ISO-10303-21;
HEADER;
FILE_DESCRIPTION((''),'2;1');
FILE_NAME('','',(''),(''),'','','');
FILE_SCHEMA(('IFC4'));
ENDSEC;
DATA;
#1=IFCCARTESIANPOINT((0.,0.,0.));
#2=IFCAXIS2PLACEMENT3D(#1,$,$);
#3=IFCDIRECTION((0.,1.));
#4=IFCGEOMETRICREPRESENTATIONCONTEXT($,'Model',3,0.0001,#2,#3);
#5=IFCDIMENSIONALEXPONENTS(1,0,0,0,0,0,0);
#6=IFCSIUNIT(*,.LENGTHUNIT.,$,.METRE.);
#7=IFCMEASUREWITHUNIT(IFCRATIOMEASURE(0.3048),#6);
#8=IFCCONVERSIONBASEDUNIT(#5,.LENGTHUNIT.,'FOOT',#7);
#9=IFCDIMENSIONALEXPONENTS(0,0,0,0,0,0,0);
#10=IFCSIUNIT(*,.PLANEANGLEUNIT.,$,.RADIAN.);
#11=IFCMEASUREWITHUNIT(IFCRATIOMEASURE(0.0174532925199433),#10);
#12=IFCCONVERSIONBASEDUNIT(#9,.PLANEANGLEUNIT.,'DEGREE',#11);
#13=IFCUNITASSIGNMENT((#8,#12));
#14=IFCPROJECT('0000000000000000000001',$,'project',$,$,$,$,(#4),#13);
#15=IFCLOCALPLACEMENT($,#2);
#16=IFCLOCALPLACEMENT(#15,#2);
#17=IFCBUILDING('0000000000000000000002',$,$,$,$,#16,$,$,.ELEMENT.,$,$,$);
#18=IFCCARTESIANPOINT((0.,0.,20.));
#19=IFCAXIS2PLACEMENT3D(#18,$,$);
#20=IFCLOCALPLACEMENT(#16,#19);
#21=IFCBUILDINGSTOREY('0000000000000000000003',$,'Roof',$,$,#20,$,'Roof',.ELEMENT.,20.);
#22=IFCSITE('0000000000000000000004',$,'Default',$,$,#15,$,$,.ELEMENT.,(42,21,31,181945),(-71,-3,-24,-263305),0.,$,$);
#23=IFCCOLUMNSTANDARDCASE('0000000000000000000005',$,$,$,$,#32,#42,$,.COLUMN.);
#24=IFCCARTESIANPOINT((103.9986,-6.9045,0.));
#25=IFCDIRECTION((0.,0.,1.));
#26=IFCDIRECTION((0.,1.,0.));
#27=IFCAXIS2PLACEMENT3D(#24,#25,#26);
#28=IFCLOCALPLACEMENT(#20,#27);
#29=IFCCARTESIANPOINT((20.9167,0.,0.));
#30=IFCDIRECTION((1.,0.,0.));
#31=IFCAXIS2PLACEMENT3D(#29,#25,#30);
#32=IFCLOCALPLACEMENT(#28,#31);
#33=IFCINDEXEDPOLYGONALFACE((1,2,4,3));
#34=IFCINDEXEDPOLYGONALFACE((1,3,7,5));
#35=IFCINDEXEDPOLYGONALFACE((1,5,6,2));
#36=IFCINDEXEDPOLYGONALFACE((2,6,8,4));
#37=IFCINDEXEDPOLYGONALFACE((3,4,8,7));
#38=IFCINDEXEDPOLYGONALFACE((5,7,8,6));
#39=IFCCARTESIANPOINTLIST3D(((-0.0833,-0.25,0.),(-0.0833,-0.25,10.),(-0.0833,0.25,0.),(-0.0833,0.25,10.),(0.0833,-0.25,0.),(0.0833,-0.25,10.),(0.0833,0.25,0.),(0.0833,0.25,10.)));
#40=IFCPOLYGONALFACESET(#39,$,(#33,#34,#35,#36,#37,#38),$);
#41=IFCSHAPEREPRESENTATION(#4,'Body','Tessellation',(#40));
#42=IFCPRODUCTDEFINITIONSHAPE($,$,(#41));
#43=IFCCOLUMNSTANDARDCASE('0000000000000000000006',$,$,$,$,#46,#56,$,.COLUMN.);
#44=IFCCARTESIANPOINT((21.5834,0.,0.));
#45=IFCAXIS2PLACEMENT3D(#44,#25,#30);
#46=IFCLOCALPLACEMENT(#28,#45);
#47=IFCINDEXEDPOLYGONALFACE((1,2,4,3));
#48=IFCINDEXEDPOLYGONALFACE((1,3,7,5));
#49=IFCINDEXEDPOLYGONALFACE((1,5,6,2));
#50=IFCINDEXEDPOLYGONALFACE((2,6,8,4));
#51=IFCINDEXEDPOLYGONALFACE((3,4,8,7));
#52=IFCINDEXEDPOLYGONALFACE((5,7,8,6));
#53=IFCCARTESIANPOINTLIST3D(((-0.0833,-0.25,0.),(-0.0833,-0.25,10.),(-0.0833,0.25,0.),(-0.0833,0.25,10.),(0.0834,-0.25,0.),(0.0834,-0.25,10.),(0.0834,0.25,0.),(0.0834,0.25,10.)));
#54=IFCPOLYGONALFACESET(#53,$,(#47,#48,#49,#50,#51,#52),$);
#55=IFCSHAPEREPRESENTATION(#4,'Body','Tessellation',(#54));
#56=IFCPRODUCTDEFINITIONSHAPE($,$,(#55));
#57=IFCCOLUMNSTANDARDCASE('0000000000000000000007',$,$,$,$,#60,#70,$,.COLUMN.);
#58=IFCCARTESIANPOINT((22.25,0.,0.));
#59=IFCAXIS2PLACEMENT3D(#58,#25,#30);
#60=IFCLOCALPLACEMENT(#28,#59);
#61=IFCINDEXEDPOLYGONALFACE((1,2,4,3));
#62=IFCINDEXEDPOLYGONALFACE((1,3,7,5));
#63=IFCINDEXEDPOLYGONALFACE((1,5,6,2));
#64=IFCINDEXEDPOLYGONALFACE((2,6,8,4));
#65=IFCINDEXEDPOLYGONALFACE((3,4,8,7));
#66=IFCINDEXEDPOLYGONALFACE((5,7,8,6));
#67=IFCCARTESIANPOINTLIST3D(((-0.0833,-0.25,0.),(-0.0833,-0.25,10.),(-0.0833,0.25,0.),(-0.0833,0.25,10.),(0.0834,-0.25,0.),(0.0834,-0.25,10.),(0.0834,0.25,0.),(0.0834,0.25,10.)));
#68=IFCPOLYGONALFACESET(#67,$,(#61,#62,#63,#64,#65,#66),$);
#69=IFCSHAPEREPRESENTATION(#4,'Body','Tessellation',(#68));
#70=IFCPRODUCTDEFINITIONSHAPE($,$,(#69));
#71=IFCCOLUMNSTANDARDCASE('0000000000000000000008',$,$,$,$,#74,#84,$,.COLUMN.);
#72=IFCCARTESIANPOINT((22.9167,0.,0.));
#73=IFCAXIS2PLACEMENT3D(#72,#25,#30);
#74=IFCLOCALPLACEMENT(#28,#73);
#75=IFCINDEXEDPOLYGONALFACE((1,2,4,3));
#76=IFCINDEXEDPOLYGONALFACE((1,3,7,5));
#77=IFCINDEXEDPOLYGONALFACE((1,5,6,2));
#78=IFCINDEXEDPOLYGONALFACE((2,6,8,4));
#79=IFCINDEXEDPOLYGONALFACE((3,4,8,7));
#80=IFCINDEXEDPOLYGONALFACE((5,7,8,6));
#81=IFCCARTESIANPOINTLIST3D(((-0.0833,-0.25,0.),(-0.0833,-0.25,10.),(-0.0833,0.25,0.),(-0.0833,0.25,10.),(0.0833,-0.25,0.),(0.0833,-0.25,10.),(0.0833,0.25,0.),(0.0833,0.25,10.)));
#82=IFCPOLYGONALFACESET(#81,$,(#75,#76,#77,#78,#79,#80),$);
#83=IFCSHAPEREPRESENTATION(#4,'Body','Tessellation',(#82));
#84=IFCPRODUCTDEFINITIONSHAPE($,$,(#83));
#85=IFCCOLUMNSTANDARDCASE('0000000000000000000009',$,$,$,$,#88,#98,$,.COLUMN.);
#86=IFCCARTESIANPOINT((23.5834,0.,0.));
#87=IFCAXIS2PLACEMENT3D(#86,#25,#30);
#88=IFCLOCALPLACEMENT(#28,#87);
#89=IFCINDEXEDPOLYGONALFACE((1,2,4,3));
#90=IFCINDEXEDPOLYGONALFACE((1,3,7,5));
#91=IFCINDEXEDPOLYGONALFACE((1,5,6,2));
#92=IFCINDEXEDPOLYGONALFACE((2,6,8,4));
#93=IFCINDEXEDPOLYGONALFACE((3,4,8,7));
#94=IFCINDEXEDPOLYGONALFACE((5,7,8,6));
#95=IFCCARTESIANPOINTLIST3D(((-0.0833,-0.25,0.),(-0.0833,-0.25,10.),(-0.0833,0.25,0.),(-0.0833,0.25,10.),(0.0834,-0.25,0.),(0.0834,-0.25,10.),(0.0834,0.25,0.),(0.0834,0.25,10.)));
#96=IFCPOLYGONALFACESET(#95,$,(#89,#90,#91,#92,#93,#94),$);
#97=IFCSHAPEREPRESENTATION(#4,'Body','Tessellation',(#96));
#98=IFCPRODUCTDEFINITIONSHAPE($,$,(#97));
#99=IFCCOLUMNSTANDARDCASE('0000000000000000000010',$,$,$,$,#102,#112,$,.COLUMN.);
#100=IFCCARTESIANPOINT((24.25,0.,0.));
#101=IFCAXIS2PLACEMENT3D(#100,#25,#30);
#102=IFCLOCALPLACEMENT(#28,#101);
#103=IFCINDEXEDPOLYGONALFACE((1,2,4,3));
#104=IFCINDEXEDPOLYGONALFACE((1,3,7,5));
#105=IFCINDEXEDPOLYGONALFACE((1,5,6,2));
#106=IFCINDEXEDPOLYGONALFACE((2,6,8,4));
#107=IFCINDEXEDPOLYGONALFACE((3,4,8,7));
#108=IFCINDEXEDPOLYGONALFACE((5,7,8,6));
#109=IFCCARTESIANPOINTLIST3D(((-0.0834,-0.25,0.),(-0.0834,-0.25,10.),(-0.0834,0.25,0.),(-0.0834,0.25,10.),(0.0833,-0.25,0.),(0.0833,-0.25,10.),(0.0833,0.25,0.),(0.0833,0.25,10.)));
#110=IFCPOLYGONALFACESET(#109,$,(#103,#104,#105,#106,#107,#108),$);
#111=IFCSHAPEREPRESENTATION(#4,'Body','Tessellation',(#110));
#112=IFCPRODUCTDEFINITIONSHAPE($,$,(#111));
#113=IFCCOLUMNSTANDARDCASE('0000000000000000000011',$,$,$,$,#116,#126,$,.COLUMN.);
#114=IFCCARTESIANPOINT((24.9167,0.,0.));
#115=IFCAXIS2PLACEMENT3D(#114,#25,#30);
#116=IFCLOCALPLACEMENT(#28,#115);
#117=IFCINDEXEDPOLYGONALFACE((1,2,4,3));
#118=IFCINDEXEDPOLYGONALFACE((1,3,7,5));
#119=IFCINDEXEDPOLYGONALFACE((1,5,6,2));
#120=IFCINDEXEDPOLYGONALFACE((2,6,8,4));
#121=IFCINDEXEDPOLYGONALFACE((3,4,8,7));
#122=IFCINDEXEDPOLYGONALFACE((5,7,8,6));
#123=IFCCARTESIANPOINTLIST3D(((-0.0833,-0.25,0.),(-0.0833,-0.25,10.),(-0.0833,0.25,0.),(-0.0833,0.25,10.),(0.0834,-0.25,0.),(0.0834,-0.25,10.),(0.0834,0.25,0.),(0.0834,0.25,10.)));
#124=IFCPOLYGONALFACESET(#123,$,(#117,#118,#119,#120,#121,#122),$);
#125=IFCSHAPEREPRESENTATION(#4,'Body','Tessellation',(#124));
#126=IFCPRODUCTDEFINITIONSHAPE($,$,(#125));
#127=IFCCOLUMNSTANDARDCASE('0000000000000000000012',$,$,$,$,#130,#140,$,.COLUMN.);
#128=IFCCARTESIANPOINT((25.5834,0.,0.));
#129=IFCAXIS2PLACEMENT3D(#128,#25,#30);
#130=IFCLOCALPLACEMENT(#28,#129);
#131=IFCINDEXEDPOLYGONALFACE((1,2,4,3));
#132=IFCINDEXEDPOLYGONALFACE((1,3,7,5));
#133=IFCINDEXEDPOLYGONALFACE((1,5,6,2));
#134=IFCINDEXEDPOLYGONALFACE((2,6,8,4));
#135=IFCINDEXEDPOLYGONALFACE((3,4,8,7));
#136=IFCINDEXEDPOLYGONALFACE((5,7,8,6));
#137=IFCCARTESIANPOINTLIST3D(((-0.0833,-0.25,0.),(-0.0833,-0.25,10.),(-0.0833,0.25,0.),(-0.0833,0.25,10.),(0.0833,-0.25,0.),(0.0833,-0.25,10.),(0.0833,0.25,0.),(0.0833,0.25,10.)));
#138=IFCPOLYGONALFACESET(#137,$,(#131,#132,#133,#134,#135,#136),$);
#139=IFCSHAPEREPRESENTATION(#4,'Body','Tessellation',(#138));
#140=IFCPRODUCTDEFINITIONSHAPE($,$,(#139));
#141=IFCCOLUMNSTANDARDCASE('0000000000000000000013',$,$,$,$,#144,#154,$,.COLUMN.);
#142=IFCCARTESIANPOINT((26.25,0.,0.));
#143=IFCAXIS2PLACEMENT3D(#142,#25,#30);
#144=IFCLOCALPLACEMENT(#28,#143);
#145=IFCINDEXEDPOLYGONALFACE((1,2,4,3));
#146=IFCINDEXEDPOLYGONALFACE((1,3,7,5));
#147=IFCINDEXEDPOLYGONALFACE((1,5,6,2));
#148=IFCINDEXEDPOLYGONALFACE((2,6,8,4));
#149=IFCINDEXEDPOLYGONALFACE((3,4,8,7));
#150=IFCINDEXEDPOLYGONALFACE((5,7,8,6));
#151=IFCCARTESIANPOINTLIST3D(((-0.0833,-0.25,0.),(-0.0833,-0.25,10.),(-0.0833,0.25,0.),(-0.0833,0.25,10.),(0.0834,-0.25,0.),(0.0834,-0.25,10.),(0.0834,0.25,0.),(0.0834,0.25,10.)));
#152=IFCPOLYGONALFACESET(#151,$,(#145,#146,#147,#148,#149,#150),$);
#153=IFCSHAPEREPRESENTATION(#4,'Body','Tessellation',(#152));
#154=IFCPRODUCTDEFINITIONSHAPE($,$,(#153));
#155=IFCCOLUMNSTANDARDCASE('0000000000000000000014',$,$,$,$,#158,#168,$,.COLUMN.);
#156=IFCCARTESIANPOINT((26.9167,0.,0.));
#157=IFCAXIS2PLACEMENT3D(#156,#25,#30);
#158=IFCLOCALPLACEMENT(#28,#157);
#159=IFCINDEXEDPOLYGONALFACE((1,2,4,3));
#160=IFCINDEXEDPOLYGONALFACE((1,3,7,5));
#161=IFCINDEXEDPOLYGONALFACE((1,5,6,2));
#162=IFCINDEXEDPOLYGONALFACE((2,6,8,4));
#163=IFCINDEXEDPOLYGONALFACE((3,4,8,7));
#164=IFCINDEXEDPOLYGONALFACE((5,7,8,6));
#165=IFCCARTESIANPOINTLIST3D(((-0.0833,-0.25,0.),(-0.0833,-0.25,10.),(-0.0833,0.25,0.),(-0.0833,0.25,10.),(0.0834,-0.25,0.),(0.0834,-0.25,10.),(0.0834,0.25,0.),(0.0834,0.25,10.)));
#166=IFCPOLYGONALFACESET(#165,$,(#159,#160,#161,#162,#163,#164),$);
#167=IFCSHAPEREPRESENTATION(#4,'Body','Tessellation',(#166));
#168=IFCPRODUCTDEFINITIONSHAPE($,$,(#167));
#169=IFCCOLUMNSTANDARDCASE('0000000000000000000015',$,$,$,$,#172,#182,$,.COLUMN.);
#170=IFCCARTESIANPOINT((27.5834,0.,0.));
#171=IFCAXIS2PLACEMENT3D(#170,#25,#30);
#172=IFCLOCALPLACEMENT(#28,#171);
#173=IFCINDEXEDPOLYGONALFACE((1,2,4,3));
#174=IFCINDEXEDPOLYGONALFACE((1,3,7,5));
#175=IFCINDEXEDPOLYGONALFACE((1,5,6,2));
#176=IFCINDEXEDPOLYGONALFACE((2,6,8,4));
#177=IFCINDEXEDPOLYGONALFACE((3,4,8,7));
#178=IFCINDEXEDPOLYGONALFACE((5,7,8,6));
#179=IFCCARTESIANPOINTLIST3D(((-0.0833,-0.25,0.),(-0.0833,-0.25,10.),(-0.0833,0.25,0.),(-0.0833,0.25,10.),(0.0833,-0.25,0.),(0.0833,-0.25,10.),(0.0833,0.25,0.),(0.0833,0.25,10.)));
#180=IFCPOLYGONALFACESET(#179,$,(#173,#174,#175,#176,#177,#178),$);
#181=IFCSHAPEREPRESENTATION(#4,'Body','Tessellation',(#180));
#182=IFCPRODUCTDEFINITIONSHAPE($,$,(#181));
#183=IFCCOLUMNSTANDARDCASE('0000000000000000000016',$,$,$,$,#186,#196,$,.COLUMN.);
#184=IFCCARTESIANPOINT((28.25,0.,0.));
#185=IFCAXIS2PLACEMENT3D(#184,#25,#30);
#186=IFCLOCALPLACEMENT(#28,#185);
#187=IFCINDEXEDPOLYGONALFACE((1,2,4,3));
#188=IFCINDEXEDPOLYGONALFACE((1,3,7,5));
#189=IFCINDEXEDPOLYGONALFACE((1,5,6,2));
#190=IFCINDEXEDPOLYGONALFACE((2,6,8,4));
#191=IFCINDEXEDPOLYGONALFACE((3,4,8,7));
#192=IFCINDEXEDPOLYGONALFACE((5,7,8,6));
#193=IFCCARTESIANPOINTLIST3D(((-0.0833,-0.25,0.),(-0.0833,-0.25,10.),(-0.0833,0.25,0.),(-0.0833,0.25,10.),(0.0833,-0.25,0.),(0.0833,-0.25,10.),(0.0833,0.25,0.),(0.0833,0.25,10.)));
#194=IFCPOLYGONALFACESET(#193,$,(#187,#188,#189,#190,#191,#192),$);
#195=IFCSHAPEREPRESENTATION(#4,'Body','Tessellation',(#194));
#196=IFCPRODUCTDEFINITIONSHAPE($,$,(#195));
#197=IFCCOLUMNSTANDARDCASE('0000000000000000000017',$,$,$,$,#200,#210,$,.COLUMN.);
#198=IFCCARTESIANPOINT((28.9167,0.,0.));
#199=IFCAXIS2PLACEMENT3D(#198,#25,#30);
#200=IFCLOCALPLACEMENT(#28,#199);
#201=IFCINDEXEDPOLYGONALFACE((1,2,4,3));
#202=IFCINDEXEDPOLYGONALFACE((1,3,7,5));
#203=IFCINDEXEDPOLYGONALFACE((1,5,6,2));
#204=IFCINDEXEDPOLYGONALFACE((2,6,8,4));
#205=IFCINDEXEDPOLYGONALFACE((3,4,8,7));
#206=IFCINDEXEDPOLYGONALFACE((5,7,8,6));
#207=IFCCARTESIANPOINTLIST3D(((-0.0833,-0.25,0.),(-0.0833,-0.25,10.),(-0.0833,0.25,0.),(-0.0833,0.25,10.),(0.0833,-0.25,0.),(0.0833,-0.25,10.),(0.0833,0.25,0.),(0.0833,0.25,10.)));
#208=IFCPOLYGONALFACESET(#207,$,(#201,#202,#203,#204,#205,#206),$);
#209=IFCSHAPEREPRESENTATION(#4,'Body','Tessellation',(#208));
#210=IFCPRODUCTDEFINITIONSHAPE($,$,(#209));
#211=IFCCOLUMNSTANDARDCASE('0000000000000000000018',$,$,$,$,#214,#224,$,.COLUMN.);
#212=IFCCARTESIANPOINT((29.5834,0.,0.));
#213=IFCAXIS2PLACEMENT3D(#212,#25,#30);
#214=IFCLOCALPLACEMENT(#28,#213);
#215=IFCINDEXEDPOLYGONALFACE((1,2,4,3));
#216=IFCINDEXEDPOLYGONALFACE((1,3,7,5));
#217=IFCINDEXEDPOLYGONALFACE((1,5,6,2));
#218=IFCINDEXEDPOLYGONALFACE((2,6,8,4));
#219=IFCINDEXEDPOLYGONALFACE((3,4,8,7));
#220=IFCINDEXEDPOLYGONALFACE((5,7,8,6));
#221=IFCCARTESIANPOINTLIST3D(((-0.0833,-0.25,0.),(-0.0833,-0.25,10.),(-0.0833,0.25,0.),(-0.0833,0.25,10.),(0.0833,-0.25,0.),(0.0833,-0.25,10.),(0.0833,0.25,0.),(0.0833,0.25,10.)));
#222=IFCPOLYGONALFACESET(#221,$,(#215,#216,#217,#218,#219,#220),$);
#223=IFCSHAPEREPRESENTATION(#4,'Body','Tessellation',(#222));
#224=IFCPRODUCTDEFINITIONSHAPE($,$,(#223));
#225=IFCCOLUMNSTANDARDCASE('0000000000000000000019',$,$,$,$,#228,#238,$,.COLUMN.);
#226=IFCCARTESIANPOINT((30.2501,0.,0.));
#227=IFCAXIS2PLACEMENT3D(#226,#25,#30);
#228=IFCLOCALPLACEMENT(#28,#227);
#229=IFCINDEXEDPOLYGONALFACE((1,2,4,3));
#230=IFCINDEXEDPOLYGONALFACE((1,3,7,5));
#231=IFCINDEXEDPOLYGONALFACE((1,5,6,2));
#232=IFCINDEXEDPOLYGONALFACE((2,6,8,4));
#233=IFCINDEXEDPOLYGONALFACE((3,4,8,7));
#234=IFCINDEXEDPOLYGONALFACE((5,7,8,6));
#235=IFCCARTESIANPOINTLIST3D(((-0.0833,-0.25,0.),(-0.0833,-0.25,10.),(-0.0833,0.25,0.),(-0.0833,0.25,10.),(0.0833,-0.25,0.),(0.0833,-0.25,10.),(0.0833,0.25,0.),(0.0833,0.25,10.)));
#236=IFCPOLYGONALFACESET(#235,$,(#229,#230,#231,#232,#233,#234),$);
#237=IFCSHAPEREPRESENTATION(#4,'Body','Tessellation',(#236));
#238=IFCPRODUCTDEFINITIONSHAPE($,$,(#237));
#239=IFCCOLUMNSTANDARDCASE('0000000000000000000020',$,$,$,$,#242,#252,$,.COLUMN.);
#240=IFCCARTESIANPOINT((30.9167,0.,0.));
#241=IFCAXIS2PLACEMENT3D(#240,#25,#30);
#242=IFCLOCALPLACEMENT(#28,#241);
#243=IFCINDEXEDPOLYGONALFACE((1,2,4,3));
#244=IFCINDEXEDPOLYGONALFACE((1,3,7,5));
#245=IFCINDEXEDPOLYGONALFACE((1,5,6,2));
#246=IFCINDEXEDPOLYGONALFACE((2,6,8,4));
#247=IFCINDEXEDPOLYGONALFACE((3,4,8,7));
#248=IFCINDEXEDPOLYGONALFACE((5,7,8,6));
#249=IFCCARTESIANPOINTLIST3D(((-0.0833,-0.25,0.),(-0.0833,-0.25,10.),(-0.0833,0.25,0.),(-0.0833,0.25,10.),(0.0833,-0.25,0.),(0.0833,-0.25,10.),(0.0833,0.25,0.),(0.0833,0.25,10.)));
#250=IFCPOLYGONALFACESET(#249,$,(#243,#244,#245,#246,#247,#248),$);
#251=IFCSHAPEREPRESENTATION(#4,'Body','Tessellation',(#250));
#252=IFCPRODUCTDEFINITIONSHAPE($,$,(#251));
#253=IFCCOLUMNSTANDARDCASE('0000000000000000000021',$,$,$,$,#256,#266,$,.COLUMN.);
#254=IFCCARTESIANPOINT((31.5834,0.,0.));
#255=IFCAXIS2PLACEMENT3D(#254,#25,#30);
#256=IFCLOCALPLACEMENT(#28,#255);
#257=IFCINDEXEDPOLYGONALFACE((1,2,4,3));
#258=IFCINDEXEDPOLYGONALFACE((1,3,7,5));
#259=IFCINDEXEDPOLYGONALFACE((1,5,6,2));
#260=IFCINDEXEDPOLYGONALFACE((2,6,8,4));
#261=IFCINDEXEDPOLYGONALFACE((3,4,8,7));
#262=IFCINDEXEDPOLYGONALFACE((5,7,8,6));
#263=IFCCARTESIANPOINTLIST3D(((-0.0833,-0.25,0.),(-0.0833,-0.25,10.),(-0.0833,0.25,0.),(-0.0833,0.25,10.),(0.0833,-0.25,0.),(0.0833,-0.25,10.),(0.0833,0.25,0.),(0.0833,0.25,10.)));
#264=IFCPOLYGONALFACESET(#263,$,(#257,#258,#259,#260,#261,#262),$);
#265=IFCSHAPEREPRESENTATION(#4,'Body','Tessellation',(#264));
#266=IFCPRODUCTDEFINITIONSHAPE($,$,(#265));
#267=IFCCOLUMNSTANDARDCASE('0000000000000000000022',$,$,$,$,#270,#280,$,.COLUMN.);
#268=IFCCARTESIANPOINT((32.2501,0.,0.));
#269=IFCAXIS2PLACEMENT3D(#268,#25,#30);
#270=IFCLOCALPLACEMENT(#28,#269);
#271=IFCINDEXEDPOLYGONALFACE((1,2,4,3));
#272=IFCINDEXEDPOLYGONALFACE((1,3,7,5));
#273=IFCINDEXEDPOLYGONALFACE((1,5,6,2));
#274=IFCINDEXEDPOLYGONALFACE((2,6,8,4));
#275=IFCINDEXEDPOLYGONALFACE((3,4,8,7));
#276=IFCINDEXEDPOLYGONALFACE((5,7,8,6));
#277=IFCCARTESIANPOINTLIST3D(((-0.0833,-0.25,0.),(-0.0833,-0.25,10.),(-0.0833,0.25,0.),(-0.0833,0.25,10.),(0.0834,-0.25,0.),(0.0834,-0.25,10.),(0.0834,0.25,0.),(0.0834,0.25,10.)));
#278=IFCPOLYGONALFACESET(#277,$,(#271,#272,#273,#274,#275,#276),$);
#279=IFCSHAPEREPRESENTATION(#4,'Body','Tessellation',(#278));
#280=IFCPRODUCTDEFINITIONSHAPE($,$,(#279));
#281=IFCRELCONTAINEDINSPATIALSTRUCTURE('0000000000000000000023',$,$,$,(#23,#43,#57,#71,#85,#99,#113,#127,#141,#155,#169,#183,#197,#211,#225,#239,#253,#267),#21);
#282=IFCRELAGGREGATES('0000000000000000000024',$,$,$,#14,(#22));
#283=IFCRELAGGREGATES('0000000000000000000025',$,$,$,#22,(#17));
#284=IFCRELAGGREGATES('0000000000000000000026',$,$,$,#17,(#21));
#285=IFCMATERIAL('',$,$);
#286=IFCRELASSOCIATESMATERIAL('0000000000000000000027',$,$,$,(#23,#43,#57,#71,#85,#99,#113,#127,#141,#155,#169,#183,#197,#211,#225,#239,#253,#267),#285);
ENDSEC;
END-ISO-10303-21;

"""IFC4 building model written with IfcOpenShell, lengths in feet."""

from ifc_helpers import new_model, entity, si_unit, converted_unit, direction, frame, origin, place, context, project, spatial, rectangle, extrude, material, element, save


model = new_model("IFC4")

# Units and contexts
model_context = context("Model", 3, precision=0.0001, world=origin(), true_north=direction((0.0, 1.0)))
ifc_project = project(units=[converted_unit("LENGTHUNIT", "FOOT", entity("IfcRatioMeasure", 0.3048), si_unit("LENGTHUNIT", "METRE"), dimensions=[1, 0, 0, 0, 0, 0, 0]), converted_unit("PLANEANGLEUNIT", "DEGREE", entity("IfcRatioMeasure", 0.0174532925199433), si_unit("PLANEANGLEUNIT", "RADIAN"), dimensions=[0, 0, 0, 0, 0, 0, 0])], contexts=[model_context])

# Site, building, storey
site_placement = place(None, origin())
site = spatial("IfcSite", under=ifc_project, at=site_placement, Name="Default", CompositionType="ELEMENT", RefLatitude=(42, 21, 31, 181945), RefLongitude=(-71, -3, -24, -263305), RefElevation=0.0)
building_placement = place(site_placement, origin())
building = spatial("IfcBuilding", under=site, at=building_placement, CompositionType="ELEMENT")
storey_placement = place(building_placement, frame((0.0, 0.0, 20.0)))
storey = spatial("IfcBuildingStorey", under=building, at=storey_placement, Name="Roof", LongName="Roof", CompositionType="ELEMENT", Elevation=20.0)

# Columns
ifc_material_1 = material(Name="")
placement_1 = place(storey_placement, frame((103.9986, -6.9045, 0.0), z_axis=(0.0, 0.0, 1.0), x_axis=(0.0, 1.0, 0.0)))
for number, where, z_axis, x_axis in (
    (1, (20.9167, 0.0, 0.0), (0.0, 0.0, 1.0), (1.0, 0.0, 0.0)),
    (2, (21.5834, 0.0, 0.0), (0.0, 0.0, 1.0), (1.0, 0.0, 0.0)),
    (3, (22.25, 0.0, 0.0), (0.0, 0.0, 1.0), (1.0, 0.0, 0.0)),
    (4, (22.9167, 0.0, 0.0), (0.0, 0.0, 1.0), (1.0, 0.0, 0.0)),
    (5, (23.5834, 0.0, 0.0), (0.0, 0.0, 1.0), (1.0, 0.0, 0.0)),
    (6, (24.25, 0.0, 0.0), (0.0, 0.0, 1.0), (1.0, 0.0, 0.0)),
    (7, (24.9167, 0.0, 0.0), (0.0, 0.0, 1.0), (1.0, 0.0, 0.0)),
    (8, (25.5834, 0.0, 0.0), (0.0, 0.0, 1.0), (1.0, 0.0, 0.0)),
    (9, (26.25, 0.0, 0.0), (0.0, 0.0, 1.0), (1.0, 0.0, 0.0)),
    (10, (26.9167, 0.0, 0.0), (0.0, 0.0, 1.0), (1.0, 0.0, 0.0)),
    (11, (27.5834, 0.0, 0.0), (0.0, 0.0, 1.0), (1.0, 0.0, 0.0)),
    (12, (28.25, 0.0, 0.0), (0.0, 0.0, 1.0), (1.0, 0.0, 0.0)),
    (13, (28.9167, 0.0, 0.0), (0.0, 0.0, 1.0), (1.0, 0.0, 0.0)),
    (14, (29.5834, 0.0, 0.0), (0.0, 0.0, 1.0), (1.0, 0.0, 0.0)),
    (15, (30.2501, 0.0, 0.0), (0.0, 0.0, 1.0), (1.0, 0.0, 0.0)),
    (16, (30.9167, 0.0, 0.0), (0.0, 0.0, 1.0), (1.0, 0.0, 0.0)),
    (17, (31.5834, 0.0, 0.0), (0.0, 0.0, 1.0), (1.0, 0.0, 0.0)),
    (18, (32.2501, 0.0, 0.0), (0.0, 0.0, 1.0), (1.0, 0.0, 0.0)),
):
    element("IfcColumnStandardCase", number, at=place(placement_1, frame(where, z_axis=z_axis, x_axis=x_axis)), inside=storey, material=ifc_material_1, PredefinedType="COLUMN", context=model_context, shape_type="SweptSolid", body=[
        extrude(rectangle(XDim=0.1667, YDim=0.5), origin(), (0.0, 0.0, 1.0), 10.0),
    ])

save(model, "model.ifc")
